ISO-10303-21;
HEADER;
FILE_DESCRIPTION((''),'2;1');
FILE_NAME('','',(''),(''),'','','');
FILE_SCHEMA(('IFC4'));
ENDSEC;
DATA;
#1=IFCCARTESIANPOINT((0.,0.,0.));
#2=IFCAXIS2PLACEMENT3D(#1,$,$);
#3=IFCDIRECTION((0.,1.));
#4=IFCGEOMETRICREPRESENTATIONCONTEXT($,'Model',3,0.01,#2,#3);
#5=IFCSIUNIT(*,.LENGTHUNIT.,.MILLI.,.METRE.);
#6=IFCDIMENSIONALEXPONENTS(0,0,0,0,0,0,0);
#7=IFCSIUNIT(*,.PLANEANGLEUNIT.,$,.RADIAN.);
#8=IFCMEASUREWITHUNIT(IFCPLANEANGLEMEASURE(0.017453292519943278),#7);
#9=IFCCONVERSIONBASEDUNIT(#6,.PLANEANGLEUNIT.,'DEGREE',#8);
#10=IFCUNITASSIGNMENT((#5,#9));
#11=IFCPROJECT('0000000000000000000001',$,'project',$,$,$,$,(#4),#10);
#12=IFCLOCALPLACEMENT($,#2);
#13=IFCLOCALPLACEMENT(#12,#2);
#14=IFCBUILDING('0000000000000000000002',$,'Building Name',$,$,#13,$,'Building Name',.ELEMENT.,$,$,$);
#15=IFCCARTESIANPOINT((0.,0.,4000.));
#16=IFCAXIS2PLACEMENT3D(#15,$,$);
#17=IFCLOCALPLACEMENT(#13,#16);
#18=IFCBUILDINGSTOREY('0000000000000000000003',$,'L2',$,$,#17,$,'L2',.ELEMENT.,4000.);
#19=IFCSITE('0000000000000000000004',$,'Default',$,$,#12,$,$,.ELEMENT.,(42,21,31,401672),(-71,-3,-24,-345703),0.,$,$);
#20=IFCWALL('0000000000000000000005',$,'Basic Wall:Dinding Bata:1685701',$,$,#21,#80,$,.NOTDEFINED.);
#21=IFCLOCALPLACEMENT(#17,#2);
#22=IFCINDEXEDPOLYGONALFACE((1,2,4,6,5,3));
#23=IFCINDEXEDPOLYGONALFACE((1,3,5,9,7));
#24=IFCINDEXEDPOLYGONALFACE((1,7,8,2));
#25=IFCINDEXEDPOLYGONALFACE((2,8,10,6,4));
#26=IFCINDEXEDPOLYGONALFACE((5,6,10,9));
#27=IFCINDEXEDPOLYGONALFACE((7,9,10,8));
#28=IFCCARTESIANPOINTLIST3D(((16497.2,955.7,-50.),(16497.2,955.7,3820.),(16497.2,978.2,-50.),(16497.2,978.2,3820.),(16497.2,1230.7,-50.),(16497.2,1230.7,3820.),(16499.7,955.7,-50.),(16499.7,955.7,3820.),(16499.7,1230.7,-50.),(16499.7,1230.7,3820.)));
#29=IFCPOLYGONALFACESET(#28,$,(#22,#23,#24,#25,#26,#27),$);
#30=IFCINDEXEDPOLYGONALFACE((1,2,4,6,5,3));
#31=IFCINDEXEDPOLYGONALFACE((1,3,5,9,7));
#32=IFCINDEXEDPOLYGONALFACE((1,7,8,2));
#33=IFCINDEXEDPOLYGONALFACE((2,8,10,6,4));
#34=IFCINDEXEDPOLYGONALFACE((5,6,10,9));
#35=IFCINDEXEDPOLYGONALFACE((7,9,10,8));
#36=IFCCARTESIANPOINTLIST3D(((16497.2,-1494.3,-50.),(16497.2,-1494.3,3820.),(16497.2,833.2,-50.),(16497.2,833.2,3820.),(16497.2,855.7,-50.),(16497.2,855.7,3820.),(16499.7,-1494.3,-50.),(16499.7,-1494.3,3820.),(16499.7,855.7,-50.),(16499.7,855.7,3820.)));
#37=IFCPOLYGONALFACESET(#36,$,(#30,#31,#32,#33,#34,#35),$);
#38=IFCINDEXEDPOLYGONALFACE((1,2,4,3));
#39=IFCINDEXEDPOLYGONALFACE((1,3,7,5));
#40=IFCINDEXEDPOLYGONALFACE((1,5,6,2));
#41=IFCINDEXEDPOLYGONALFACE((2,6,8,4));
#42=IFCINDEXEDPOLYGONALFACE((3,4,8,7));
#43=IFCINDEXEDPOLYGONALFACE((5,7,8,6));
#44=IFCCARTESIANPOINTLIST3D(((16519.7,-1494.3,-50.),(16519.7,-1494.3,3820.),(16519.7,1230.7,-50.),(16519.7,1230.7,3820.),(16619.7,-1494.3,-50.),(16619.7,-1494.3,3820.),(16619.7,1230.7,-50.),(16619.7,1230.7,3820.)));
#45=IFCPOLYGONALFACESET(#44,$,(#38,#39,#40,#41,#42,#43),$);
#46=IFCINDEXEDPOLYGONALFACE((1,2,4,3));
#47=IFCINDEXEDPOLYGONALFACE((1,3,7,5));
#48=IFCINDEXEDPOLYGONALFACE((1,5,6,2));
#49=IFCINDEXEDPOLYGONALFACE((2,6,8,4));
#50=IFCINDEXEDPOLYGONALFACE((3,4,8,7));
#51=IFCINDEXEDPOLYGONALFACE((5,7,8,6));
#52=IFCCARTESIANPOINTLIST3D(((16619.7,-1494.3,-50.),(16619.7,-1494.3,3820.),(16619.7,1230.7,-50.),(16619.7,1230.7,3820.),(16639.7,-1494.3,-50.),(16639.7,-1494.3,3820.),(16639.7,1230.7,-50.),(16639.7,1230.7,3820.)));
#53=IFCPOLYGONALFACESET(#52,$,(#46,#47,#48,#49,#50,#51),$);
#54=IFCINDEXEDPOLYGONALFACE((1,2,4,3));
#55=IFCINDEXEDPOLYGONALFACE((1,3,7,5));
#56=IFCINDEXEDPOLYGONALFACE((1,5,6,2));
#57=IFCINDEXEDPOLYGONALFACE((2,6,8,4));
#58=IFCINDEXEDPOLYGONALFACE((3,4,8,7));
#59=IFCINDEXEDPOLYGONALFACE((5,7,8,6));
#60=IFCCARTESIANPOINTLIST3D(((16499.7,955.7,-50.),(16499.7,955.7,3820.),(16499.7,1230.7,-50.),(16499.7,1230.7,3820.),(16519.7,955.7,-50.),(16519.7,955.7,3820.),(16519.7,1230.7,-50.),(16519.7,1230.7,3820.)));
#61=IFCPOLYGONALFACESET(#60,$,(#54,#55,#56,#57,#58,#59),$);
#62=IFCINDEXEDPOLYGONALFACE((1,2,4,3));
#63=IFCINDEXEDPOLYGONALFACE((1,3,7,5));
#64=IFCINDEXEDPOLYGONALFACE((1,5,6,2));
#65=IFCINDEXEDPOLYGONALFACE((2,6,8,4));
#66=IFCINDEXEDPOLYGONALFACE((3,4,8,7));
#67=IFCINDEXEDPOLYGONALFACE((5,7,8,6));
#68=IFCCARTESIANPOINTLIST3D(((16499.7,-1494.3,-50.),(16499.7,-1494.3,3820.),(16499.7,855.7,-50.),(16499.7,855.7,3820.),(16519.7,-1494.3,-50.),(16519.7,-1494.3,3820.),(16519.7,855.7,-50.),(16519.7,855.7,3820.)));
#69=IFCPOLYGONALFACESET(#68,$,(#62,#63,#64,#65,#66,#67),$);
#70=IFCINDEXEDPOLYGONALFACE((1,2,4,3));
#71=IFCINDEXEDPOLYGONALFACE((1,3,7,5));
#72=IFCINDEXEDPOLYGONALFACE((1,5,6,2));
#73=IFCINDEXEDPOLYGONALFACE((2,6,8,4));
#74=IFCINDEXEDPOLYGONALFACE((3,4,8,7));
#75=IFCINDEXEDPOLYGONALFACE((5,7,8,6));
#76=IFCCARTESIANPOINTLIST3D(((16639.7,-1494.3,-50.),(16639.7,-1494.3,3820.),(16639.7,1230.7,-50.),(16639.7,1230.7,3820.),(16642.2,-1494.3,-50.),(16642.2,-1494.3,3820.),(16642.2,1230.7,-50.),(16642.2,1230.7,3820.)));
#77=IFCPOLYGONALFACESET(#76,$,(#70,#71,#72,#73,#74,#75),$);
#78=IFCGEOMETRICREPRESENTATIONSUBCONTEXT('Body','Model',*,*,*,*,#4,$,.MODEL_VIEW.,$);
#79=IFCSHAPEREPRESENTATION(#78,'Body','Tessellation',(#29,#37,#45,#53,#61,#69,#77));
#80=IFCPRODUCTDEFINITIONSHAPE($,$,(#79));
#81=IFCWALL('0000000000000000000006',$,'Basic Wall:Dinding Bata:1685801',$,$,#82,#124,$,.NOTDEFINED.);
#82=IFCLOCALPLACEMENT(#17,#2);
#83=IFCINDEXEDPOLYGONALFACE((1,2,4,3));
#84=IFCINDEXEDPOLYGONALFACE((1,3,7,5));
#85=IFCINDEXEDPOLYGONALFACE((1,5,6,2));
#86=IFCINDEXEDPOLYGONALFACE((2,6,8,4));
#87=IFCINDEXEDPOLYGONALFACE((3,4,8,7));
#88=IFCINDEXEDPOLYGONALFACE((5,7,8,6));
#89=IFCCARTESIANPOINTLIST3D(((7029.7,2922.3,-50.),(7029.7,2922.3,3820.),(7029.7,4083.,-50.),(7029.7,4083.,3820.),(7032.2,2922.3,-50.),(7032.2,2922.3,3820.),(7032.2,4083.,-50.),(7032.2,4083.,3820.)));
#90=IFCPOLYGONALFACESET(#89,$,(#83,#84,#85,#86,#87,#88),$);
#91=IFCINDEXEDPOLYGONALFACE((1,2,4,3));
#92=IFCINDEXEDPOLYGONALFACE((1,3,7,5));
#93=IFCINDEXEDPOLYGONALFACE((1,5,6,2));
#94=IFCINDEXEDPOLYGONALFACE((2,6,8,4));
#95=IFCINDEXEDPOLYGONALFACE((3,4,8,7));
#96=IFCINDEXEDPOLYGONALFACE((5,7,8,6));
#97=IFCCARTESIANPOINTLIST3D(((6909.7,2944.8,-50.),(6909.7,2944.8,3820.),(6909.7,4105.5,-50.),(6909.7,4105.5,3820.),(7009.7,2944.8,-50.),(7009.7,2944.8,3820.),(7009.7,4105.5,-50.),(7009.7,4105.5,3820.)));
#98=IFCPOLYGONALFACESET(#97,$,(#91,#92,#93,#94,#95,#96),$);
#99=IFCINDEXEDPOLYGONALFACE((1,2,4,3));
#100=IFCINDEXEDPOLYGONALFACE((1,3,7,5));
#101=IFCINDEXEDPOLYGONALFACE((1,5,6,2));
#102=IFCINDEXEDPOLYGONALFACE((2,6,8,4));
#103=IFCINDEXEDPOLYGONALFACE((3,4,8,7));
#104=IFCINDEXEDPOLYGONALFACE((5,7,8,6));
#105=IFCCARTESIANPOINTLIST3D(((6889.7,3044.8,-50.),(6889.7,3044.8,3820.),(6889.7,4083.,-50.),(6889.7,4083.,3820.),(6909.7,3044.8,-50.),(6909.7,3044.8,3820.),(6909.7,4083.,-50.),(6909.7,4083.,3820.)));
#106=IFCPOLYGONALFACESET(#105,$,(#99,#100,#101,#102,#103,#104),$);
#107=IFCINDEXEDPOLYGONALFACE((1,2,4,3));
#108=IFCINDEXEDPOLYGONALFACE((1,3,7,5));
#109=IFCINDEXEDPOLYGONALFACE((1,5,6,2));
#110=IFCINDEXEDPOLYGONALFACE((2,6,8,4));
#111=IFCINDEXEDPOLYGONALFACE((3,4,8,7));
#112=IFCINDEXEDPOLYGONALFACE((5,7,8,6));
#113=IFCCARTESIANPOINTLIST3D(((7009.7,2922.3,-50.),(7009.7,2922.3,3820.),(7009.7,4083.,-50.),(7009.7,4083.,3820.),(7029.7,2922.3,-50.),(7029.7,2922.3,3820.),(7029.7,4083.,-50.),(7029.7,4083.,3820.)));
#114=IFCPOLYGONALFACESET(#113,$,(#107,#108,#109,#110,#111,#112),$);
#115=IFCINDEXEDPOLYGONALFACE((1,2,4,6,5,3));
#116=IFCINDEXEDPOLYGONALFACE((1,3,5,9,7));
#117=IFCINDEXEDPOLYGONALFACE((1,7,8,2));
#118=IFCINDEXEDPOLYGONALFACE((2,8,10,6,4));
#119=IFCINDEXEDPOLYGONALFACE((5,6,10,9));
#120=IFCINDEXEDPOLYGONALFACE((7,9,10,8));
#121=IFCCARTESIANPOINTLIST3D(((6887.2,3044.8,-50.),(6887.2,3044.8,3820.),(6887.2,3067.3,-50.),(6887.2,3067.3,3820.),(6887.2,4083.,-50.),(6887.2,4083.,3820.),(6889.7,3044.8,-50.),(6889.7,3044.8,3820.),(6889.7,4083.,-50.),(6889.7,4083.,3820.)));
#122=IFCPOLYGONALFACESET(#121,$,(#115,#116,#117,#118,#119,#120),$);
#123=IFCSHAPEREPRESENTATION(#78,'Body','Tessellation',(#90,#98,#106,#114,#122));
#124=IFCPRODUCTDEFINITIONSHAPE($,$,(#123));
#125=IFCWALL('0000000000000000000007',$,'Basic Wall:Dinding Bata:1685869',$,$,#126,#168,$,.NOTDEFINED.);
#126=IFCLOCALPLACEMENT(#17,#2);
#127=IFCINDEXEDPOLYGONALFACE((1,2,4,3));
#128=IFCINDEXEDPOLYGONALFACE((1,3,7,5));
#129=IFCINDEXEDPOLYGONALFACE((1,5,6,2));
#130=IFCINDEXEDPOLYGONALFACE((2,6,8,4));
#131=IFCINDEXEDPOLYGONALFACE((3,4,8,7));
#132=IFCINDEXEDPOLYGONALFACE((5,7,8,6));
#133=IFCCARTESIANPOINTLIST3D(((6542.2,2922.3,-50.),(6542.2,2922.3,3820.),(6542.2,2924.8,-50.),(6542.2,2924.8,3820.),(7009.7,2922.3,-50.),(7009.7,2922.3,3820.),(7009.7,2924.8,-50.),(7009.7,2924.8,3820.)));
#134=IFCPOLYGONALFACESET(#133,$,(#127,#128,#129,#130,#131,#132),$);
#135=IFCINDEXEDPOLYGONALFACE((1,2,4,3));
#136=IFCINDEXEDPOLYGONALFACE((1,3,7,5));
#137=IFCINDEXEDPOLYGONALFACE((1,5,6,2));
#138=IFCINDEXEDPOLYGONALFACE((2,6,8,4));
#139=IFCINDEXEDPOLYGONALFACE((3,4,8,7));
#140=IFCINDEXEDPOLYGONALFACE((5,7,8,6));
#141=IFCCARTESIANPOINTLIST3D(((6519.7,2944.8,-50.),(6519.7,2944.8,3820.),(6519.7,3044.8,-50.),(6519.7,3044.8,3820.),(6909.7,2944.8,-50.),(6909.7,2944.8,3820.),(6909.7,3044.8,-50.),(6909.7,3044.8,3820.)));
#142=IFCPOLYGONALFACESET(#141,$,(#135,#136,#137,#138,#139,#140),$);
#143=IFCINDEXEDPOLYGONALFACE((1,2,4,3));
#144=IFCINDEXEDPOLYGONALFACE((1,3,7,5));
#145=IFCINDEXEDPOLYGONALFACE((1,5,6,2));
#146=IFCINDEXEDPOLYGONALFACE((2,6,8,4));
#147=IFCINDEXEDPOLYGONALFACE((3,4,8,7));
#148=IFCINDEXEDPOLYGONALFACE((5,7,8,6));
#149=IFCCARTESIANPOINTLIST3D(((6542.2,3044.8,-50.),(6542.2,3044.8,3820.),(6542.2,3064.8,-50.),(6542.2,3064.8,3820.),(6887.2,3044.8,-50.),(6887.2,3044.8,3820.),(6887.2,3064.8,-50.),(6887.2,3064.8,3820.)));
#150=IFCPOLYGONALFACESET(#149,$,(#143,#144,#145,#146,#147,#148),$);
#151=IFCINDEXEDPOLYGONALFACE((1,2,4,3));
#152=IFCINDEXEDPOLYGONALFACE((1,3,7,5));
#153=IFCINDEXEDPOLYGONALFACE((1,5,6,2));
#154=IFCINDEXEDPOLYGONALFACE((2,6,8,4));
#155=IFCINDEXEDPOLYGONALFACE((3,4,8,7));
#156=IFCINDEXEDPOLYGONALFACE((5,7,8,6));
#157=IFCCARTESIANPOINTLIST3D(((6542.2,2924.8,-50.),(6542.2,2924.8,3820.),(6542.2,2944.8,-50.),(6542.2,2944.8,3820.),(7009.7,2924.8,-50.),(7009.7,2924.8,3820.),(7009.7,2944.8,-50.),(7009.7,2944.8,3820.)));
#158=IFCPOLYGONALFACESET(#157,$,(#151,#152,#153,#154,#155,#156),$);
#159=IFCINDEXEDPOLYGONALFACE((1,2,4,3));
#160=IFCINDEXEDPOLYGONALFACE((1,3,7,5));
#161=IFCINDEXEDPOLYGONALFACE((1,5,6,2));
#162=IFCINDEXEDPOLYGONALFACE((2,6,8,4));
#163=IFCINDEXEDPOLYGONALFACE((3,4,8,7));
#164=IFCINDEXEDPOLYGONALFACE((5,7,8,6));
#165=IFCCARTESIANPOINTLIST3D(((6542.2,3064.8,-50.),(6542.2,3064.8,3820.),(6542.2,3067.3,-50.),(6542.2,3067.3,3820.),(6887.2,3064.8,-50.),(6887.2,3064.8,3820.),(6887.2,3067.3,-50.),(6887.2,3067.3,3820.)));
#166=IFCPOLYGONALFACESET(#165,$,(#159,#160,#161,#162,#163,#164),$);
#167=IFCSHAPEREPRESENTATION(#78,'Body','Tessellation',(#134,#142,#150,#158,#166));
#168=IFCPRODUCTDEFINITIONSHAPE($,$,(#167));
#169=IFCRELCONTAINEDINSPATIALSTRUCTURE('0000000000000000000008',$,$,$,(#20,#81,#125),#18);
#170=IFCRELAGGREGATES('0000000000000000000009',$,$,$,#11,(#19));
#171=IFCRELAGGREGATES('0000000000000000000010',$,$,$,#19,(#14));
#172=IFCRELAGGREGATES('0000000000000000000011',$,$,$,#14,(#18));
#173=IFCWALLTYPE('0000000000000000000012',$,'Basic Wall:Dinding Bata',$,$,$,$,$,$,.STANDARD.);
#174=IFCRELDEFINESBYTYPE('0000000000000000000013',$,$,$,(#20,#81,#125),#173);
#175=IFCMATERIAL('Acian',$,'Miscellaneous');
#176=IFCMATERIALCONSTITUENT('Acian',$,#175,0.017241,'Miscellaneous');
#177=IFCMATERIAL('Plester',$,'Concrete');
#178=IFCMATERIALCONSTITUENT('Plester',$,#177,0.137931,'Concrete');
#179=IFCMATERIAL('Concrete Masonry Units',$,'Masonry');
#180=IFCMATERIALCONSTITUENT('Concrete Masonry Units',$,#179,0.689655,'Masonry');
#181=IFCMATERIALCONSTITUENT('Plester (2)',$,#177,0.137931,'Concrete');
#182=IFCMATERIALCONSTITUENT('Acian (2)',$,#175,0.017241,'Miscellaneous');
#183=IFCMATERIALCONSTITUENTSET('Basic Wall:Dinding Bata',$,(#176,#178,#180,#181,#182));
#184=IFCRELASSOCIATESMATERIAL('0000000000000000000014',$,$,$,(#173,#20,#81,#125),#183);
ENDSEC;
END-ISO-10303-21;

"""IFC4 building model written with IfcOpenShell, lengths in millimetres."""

from ifc_helpers import new_model, entity, si_unit, converted_unit, direction, frame, origin, place, context, subcontext, project, spatial, indexed_curve, outline, extrude, material, constituent, constituent_set, type_object, element, save


model = new_model("IFC4")

# Units and contexts
model_context = context("Model", 3, precision=0.01, world=origin(), true_north=direction((0.0, 1.0)))
body_context = subcontext(model_context, "Body", "Model", "MODEL_VIEW")
ifc_project = project(units=[si_unit("LENGTHUNIT", "METRE", prefix="MILLI"), converted_unit("PLANEANGLEUNIT", "DEGREE", entity("IfcPlaneAngleMeasure", 0.017453292519943278), si_unit("PLANEANGLEUNIT", "RADIAN"), dimensions=[0, 0, 0, 0, 0, 0, 0])], contexts=[model_context])

# Site, building, storey
site_placement = place(None, origin())
site = spatial("IfcSite", under=ifc_project, at=site_placement, Name="Default", CompositionType="ELEMENT", RefLatitude=(42, 21, 31, 401672), RefLongitude=(-71, -3, -24, -345703), RefElevation=0.0)
building_placement = place(site_placement, origin())
building = spatial("IfcBuilding", under=site, at=building_placement, Name="Building Name", LongName="Building Name", CompositionType="ELEMENT")
storey_placement = place(building_placement, frame((0.0, 0.0, 4000.0)))
storey = spatial("IfcBuildingStorey", under=building, at=storey_placement, Name="L2", LongName="L2", CompositionType="ELEMENT", Elevation=4000.0)

# Walls
ifc_material_1 = material(Name="Acian", Category="Miscellaneous")
ifc_constituent_1 = constituent(ifc_material_1, Name="Acian", Category="Miscellaneous", fraction=0.017241)
ifc_material_2 = material(Name="Plester", Category="Concrete")
ifc_constituent_2 = constituent(ifc_material_2, Name="Plester", Category="Concrete", fraction=0.137931)
ifc_material_3 = material(Name="Concrete Masonry Units", Category="Masonry")
ifc_constituent_3 = constituent(ifc_material_3, Name="Concrete Masonry Units", Category="Masonry", fraction=0.689655)
ifc_constituent_4 = constituent(ifc_material_2, Name="Plester (2)", Category="Concrete", fraction=0.137931)
ifc_constituent_5 = constituent(ifc_material_1, Name="Acian (2)", Category="Miscellaneous", fraction=0.017241)
ifc_constituent_set = constituent_set(constituents=[ifc_constituent_1, ifc_constituent_2, ifc_constituent_3, ifc_constituent_4, ifc_constituent_5], Name="Basic Wall:Dinding Bata")
wall_type = type_object("IfcWallType", Name="Basic Wall:Dinding Bata", PredefinedType="STANDARD", material=ifc_constituent_set)
wall_1_placement = place(storey_placement, frame((16569.7, -1494.3, -50.0), z_axis=(0.0, 0.0, 1.0), x_axis=(0.0, 1.0, 0.0)))
element("IfcWall", 1, at=wall_1_placement, inside=storey, type_object=wall_type, material=ifc_constituent_set, Name="Basic Wall:Dinding Bata:1685701", PredefinedType="NOTDEFINED", context=body_context, shape_type="SweptSolid", body=[
    extrude(outline(indexed_curve([(92.0, -1.0), (114.5, -1.0), (114.5, 1.5), (-160.5, 1.5), (-160.5, -1.0), (92.0, -1.0)], self_intersect=False)), frame((2564.5, 71.5, 0.0), z_axis=(0.0, 0.0, 1.0), x_axis=(-1.0, 0.0, 0.0)), (0.0, 0.0, 1.0), 3870.0),
    extrude(outline(indexed_curve([(-1405.5, -1.5), (944.5, -1.5), (944.5, 1.0), (922.0, 1.0), (-1405.5, 1.0), (-1405.5, -1.5)], self_intersect=False)), frame((1405.5, 71.5, 0.0)), (0.0, 0.0, 1.0), 3870.0),
    extrude(outline(indexed_curve([(-1362.5, -50.0), (1362.5, -50.0), (1362.5, 50.0), (-1362.5, 50.0), (-1362.5, -50.0)], self_intersect=False)), frame((1362.5, 0.0, 0.0)), (0.0, 0.0, 1.0), 3870.0),
    extrude(outline(indexed_curve([(-1362.5, -10.0), (1362.5, -10.0), (1362.5, 10.0), (-1362.5, 10.0), (-1362.5, -10.0)], self_intersect=False)), frame((1362.5, -60.0, 0.0)), (0.0, 0.0, 1.0), 3870.0),
    extrude(outline(indexed_curve([(-137.5, -10.0), (137.5, -10.0), (137.5, 10.0), (-137.5, 10.0), (-137.5, -10.0)], self_intersect=False)), frame((2587.5, 60.0, 0.0), z_axis=(0.0, 0.0, 1.0), x_axis=(-1.0, 0.0, 0.0)), (0.0, 0.0, 1.0), 3870.0),
    extrude(outline(indexed_curve([(-1175.0, -10.0), (1175.0, -10.0), (1175.0, 10.0), (-1175.0, 10.0), (-1175.0, -10.0)], self_intersect=False)), frame((1175.0, 60.0, 0.0)), (0.0, 0.0, 1.0), 3870.0),
    extrude(outline(indexed_curve([(-1.3, -1362.5), (1.2, -1362.5), (1.3, 1362.5), (-1.2, 1362.5), (-1.3, -1362.5)], self_intersect=False)), frame((1362.5, -71.2, 0.0), z_axis=(0.0, 0.0, 1.0), x_axis=(0.0, 1.0, 0.0)), (0.0, 0.0, 1.0), 3870.0),
])
wall_2_placement = place(storey_placement, frame((6959.7, 4083.0, -50.0), z_axis=(0.0, 0.0, 1.0), x_axis=(0.0, -1.0, 0.0)))
element("IfcWall", 2, at=wall_2_placement, inside=storey, type_object=wall_type, material=ifc_constituent_set, Name="Basic Wall:Dinding Bata:1685801", PredefinedType="NOTDEFINED", context=body_context, shape_type="SweptSolid", body=[
    extrude(outline(indexed_curve([(-1.3, -580.3), (1.2, -580.3), (1.3, 580.3), (-1.2, 580.3), (-1.3, -580.3)], self_intersect=False)), frame((580.3, 71.2, 0.0), z_axis=(0.0, 0.0, 1.0), x_axis=(0.0, -1.0, 0.0)), (0.0, 0.0, 1.0), 3870.0),
    extrude(outline(indexed_curve([(-580.3, -50.0), (580.3, -50.0), (580.3, 50.0), (-580.3, 50.0), (-580.3, -50.0)], self_intersect=False)), frame((557.8, 0.0, 0.0)), (0.0, 0.0, 1.0), 3870.0),
    extrude(outline(indexed_curve([(-519.1, -10.0), (519.1, -10.0), (519.1, 10.0), (-519.1, 10.0), (-519.1, -10.0)], self_intersect=False)), frame((519.1, -60.0, 0.0)), (0.0, 0.0, 1.0), 3870.0),
    extrude(outline(indexed_curve([(-580.3, -10.0), (580.3, -10.0), (580.3, 10.0), (-580.3, 10.0), (-580.3, -10.0)], self_intersect=False)), frame((580.3, 60.0, 0.0)), (0.0, 0.0, 1.0), 3870.0),
    extrude(outline(indexed_curve([(397.3, -1.0), (419.8, -1.0), (419.8, 1.5), (-618.4, 1.5), (-618.4, -1.0), (397.3, -1.0)], self_intersect=False)), frame((618.4, -71.5, 0.0)), (0.0, 0.0, 1.0), 3870.0),
])
wall_3_placement = place(storey_placement, frame((6887.2, 2994.8, -50.0), z_axis=(0.0, 0.0, 1.0), x_axis=(-1.0, 0.0, 0.0)))
element("IfcWall", 3, at=wall_3_placement, inside=storey, type_object=wall_type, material=ifc_constituent_set, Name="Basic Wall:Dinding Bata:1685869", PredefinedType="NOTDEFINED", context=body_context, shape_type="SweptSolid", body=[
    extrude(outline(indexed_curve([(-1.3, -233.8), (1.2, -233.8), (1.3, 233.8), (-1.2, 233.8), (-1.3, -233.8)], self_intersect=False)), frame((111.3, 71.3, 0.0), z_axis=(0.0, 0.0, 1.0), x_axis=(0.0, -1.0, 0.0)), (0.0, 0.0, 1.0), 3870.0),
    extrude(outline(indexed_curve([(-195.0, -50.0), (195.0, -50.0), (195.0, 50.0), (-195.0, 50.0), (-195.0, -50.0)], self_intersect=False)), frame((172.5, 0.0, 0.0)), (0.0, 0.0, 1.0), 3870.0),
    extrude(outline(indexed_curve([(-172.5, -10.0), (172.5, -10.0), (172.5, 10.0), (-172.5, 10.0), (-172.5, -10.0)], self_intersect=False)), frame((172.5, -60.0, 0.0)), (0.0, 0.0, 1.0), 3870.0),
    extrude(outline(indexed_curve([(-233.8, -10.0), (233.8, -10.0), (233.8, 10.0), (-233.8, 10.0), (-233.8, -10.0)], self_intersect=False)), frame((111.3, 60.0, 0.0)), (0.0, 0.0, 1.0), 3870.0),
    extrude(outline(indexed_curve([(-1.3, -172.5), (1.2, -172.5), (1.3, 172.5), (-1.2, 172.5), (-1.3, -172.5)], self_intersect=False)), frame((172.5, -71.3, 0.0), z_axis=(0.0, 0.0, 1.0), x_axis=(0.0, 1.0, 0.0)), (0.0, 0.0, 1.0), 3870.0),
])

save(model, "model.ifc")
